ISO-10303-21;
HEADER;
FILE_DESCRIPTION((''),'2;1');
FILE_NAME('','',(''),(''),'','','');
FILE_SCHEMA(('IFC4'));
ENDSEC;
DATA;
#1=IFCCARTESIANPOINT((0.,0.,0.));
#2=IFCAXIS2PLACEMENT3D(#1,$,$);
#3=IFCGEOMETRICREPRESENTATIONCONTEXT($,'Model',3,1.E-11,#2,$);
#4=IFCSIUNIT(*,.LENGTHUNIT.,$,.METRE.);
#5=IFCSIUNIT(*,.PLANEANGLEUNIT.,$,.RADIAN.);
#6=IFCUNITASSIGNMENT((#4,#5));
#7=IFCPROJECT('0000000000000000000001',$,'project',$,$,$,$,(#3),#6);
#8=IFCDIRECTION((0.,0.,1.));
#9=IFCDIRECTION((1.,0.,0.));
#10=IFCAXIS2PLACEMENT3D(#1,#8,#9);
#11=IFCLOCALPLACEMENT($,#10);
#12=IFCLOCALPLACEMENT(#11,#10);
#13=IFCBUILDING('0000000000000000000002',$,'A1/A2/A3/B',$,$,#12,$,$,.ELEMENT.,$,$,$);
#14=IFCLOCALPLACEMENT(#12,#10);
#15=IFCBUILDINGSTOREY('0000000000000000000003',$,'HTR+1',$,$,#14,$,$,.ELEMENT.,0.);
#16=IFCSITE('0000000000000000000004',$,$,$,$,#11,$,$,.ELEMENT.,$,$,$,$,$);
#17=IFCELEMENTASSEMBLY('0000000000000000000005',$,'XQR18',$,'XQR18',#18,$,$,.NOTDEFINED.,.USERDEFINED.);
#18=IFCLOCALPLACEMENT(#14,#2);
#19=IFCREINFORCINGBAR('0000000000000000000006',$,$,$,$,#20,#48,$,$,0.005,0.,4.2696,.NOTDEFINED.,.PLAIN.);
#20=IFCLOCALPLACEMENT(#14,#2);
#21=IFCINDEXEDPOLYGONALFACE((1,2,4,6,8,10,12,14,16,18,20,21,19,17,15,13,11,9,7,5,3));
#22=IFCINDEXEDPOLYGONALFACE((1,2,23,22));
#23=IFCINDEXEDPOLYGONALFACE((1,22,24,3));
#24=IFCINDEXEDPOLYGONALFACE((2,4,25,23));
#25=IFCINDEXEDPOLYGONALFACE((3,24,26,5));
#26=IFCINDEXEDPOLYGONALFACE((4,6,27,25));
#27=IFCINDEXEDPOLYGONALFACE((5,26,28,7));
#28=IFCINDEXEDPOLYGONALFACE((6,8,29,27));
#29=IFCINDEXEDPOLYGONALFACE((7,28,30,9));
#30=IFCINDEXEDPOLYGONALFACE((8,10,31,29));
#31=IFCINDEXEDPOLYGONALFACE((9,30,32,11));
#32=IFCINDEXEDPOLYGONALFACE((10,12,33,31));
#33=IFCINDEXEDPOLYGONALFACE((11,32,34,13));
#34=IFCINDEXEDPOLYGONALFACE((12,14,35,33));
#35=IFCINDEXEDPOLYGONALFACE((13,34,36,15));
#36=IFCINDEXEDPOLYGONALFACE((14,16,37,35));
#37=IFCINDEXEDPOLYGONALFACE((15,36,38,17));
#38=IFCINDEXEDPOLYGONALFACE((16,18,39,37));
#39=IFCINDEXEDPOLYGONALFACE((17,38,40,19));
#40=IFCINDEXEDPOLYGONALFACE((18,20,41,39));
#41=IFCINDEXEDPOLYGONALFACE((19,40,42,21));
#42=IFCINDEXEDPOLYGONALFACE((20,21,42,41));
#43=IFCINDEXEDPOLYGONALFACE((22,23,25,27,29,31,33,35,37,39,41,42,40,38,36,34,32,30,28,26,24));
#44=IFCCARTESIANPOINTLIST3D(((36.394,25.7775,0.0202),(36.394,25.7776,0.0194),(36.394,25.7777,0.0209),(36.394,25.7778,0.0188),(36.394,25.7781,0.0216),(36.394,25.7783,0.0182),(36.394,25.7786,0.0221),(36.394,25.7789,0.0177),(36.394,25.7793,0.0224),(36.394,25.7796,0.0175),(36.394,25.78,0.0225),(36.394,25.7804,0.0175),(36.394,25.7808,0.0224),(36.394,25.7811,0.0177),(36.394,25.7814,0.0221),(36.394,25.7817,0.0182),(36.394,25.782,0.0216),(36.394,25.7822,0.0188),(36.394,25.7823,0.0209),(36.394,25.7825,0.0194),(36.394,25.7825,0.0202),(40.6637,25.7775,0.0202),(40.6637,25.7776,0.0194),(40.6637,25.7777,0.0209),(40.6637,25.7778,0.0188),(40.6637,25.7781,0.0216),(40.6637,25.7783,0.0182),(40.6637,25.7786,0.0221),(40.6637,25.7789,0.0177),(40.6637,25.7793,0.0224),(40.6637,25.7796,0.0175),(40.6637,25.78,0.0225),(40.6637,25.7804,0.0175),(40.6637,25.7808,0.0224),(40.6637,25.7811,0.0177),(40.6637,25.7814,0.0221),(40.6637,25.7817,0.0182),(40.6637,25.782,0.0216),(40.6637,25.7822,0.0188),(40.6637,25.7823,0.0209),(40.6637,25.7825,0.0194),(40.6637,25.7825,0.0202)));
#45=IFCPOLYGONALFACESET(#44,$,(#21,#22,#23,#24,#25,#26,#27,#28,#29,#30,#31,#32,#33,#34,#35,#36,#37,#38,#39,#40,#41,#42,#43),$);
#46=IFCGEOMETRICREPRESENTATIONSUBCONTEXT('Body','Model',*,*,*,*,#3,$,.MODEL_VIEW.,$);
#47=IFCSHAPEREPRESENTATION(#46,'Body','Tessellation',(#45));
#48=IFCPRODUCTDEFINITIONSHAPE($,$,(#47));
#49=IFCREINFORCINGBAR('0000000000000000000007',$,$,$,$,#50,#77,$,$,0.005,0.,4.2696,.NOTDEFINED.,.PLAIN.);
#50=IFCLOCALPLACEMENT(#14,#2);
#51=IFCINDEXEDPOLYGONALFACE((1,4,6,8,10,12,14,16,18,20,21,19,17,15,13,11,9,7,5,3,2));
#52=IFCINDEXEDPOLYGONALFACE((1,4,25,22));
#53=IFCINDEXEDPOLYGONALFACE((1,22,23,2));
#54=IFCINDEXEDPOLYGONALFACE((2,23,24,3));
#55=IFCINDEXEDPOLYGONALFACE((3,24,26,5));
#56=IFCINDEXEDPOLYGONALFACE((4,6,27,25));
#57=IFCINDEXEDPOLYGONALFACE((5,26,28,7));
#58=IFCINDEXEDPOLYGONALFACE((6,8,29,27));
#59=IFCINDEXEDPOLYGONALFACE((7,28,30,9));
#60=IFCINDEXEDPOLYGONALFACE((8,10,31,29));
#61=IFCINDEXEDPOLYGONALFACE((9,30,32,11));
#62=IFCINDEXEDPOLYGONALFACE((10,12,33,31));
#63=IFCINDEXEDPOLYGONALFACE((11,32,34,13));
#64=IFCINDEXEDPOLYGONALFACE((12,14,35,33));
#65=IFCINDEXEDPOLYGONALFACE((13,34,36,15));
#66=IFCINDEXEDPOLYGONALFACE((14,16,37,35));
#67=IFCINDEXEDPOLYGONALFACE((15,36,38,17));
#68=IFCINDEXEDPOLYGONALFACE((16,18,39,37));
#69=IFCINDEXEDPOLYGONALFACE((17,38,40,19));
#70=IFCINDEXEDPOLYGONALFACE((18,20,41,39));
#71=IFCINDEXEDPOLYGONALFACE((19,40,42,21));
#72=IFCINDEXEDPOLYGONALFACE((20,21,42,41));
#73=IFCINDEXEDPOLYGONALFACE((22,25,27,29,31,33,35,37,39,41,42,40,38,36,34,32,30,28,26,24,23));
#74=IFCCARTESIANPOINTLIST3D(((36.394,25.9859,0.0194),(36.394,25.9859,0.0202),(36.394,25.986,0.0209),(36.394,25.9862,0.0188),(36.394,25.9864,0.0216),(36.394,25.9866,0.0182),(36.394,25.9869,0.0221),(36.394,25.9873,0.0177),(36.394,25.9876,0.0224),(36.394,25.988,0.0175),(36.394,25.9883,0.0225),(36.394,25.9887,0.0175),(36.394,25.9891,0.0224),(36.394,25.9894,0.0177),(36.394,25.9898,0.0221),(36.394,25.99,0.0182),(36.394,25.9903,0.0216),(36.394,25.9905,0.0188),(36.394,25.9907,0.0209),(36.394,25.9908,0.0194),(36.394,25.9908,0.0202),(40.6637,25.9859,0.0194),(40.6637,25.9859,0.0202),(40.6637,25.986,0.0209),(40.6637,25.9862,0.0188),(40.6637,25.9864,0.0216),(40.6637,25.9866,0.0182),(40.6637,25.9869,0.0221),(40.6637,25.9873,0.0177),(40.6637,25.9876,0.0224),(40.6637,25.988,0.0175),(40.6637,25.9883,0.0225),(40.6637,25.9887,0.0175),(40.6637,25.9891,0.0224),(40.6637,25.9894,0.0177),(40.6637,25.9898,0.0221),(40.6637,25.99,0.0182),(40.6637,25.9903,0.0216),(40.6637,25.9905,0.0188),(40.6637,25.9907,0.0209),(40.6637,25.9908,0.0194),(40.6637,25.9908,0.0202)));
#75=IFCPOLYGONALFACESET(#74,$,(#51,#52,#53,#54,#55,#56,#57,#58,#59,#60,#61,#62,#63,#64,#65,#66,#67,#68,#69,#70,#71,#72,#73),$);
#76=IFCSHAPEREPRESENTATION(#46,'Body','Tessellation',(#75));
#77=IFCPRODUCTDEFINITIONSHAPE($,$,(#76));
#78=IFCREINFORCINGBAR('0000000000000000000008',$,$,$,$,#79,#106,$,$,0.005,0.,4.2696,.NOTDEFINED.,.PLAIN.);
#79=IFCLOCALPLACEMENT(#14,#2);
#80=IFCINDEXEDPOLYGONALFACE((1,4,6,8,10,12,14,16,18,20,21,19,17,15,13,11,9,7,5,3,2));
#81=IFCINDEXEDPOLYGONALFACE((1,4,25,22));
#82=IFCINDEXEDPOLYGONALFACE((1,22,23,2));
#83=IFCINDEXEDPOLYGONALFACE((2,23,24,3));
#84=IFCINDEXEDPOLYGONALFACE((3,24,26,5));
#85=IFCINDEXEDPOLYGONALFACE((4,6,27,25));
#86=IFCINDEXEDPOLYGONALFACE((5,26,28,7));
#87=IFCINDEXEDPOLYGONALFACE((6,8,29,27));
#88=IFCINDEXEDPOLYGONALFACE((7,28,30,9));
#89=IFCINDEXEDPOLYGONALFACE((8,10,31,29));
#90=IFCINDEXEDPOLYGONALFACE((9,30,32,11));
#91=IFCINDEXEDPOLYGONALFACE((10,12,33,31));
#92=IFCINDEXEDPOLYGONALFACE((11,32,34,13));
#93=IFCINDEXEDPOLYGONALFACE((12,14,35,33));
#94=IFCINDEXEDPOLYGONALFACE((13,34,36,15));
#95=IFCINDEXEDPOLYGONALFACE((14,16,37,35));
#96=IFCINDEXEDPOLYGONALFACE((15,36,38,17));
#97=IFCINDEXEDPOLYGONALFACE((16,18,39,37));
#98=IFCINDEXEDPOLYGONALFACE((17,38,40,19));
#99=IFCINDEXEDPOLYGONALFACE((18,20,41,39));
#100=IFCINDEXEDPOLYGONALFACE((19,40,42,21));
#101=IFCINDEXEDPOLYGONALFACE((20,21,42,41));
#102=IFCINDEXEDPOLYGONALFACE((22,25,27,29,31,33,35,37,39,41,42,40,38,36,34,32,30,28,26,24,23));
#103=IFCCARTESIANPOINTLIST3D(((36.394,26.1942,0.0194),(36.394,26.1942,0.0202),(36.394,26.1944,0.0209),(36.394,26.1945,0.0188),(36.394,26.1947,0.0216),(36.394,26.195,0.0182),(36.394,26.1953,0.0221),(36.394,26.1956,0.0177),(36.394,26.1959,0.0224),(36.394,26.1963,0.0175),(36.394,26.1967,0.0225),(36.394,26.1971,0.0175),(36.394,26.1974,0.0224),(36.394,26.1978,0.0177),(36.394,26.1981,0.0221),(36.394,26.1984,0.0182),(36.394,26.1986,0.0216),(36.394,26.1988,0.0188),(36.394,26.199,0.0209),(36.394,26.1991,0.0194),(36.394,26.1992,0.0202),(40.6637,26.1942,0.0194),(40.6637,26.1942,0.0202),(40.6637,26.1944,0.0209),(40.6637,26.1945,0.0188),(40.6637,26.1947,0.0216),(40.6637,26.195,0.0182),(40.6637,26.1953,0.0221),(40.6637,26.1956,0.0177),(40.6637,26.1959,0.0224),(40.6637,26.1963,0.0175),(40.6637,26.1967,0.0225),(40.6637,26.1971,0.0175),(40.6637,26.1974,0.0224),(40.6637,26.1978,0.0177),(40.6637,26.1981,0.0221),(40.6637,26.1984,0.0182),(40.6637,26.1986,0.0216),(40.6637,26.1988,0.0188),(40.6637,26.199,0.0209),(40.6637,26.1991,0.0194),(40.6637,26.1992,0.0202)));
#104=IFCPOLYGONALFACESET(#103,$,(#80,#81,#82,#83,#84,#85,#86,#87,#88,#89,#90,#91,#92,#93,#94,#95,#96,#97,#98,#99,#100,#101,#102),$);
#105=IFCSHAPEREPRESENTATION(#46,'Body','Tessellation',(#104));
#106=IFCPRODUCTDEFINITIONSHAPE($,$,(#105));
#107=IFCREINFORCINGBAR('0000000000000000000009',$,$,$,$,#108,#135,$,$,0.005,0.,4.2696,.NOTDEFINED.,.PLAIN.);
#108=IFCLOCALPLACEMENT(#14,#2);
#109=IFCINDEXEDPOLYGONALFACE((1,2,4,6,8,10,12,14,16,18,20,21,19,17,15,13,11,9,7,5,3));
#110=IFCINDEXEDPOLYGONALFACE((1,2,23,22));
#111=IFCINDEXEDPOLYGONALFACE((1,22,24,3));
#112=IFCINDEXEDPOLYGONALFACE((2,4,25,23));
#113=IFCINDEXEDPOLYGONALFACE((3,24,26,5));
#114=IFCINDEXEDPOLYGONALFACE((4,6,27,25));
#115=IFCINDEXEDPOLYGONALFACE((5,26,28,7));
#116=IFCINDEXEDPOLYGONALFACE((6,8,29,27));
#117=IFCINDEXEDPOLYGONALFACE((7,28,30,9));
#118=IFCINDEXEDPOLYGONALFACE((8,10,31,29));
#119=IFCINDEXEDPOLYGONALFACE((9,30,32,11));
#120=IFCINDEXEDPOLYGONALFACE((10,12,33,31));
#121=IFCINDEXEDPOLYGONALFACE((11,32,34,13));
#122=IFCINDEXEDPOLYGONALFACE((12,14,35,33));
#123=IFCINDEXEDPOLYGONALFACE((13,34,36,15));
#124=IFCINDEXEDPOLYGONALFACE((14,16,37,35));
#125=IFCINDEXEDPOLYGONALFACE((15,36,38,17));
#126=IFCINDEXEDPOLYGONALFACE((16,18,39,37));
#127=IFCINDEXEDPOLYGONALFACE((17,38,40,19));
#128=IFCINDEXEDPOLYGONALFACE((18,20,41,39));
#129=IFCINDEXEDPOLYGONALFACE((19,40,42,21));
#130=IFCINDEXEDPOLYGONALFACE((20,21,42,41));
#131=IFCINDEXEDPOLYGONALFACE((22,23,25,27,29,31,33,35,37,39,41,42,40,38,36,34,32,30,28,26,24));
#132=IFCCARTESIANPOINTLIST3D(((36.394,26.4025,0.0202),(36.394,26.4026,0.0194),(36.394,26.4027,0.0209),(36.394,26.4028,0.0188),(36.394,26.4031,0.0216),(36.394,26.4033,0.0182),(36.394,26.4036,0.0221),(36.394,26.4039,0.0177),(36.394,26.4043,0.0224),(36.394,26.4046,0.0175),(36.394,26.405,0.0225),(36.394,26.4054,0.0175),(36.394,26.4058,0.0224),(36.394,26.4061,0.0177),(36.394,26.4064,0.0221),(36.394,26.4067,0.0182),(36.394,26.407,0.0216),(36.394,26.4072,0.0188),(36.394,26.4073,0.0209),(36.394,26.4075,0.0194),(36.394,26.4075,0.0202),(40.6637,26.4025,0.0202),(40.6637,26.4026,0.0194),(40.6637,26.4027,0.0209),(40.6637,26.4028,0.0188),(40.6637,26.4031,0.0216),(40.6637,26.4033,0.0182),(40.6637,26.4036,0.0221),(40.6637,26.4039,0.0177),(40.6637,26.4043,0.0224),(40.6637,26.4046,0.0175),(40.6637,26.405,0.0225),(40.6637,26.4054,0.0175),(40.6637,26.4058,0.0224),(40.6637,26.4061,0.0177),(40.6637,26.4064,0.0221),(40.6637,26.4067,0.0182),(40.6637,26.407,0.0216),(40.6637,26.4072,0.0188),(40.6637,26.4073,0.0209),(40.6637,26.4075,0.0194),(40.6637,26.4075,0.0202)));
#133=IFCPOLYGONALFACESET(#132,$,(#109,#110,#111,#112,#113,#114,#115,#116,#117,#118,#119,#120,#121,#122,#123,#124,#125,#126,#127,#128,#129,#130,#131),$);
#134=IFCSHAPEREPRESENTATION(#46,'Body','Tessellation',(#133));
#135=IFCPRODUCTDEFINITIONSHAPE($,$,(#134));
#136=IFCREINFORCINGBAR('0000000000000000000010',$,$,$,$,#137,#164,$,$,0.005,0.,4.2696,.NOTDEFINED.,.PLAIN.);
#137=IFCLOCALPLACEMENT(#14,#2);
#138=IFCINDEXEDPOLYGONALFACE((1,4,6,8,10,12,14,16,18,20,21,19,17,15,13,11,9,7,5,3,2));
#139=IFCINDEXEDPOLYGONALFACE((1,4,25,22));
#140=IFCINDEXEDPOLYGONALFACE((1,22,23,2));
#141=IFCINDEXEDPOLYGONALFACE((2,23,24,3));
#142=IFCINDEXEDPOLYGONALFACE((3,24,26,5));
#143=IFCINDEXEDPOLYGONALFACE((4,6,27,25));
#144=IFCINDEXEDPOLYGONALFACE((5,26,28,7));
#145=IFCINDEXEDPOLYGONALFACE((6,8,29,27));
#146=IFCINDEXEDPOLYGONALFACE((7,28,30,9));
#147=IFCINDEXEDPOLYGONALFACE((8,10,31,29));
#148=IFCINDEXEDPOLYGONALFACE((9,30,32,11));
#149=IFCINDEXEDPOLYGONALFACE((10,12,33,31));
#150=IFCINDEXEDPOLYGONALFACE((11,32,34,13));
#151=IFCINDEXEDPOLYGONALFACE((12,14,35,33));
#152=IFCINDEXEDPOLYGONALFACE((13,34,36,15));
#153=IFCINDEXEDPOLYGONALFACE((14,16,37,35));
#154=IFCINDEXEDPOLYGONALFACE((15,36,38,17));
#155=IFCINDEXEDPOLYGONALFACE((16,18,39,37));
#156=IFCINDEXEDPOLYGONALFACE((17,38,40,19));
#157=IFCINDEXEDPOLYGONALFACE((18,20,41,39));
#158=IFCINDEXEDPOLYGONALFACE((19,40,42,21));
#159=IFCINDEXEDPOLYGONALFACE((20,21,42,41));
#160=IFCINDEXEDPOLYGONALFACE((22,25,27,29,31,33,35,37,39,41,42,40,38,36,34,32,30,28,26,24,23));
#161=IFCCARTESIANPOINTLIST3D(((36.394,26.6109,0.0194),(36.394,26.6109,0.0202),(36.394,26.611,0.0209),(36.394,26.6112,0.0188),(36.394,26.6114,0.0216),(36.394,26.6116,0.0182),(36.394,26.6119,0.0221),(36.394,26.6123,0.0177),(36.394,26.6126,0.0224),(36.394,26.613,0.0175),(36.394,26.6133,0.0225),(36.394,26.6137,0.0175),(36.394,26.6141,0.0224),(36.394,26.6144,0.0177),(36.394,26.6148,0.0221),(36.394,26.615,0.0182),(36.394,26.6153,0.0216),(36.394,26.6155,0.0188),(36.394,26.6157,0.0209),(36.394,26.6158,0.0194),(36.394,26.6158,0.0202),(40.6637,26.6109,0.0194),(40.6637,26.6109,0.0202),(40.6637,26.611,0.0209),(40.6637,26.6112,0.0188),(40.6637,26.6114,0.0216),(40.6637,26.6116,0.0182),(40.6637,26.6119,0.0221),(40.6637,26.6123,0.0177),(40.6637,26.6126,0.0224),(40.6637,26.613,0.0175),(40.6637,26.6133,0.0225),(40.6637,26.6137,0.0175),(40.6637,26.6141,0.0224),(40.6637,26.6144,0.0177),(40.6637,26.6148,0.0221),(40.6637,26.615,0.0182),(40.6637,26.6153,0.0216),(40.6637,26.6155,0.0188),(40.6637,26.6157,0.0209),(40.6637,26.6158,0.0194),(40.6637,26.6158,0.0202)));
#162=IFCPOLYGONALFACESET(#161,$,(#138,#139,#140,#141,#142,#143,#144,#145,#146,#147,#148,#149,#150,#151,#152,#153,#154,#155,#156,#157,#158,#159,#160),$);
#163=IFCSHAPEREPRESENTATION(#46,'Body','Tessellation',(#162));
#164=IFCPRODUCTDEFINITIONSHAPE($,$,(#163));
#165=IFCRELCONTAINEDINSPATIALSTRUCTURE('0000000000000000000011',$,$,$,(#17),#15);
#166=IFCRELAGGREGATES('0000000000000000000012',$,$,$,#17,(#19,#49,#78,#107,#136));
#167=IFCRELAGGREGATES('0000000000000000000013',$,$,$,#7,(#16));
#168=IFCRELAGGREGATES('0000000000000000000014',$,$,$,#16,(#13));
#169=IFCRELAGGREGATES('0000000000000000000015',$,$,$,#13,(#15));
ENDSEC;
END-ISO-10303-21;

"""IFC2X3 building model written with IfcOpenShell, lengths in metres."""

from ifc_helpers import new_model, entity, si_unit, origin, origin_with_axes, place, context, subcontext, project, spatial, shape, element, aggregate, save


model = new_model("IFC2X3")

# Units and contexts
model_context = context("Model", 3, precision=1e-11, world=origin())
body_context = subcontext(model_context, "Body", "Model", "MODEL_VIEW")
ifc_project = project(units=[si_unit("LENGTHUNIT", "METRE"), si_unit("PLANEANGLEUNIT", "RADIAN")], contexts=[model_context])

# Site, building, storey
site_placement = place(None, origin_with_axes())
site = spatial("IfcSite", under=ifc_project, at=site_placement, CompositionType="ELEMENT")
building_placement = place(site_placement, origin_with_axes())
building = spatial("IfcBuilding", under=site, at=building_placement, Name="A1/A2/A3/B", CompositionType="ELEMENT")
storey_placement = place(building_placement, origin_with_axes())
storey = spatial("IfcBuildingStorey", under=building, at=storey_placement, Name="HTR+1", CompositionType="ELEMENT", Elevation=0.0)

# Element assembly, reinforcing bars
assembly_1_placement = place(storey_placement, origin_with_axes())
assembly_1 = element("IfcElementAssembly", 1, at=assembly_1_placement, inside=storey, Name="XQR18", ObjectType="XQR18", AssemblyPlace="NOTDEFINED", PredefinedType="USERDEFINED")
reinforcing_bar_1_placement = place(assembly_1_placement, origin_with_axes())
reinforcing_bar_1 = element("IfcReinforcingBar", 2, at=reinforcing_bar_1_placement, BarLength=4.2696, BarRole="NOTDEFINED", BarSurface="PLAIN", CrossSectionArea=0.0, NominalDiameter=0.005, shapes=[
    shape(body_context, "Body", "AdvancedSweptSolid", [entity("IfcSweptDiskSolid", entity("IfcPolyline", [entity("IfcCartesianPoint", [36.394, 25.78, 0.02]), entity("IfcCartesianPoint", [40.6637, 25.78, 0.02])]), 0.0025, None, 0.0, 4.2696)]),
    shape(body_context, "Body", "AdvancedSweptSolid", [entity("IfcSweptDiskSolid", entity("IfcPolyline", [entity("IfcCartesianPoint", [36.394, 25.78, 0.02]), entity("IfcCartesianPoint", [40.6637, 25.78, 0.02])]), 0.0025, None, 0.0, 4.2696)]),
])
reinforcing_bar_2_placement = place(assembly_1_placement, origin_with_axes())
reinforcing_bar_2 = element("IfcReinforcingBar", 3, at=reinforcing_bar_2_placement, BarLength=4.2696, BarRole="NOTDEFINED", BarSurface="PLAIN", CrossSectionArea=0.0, NominalDiameter=0.005, shapes=[
    shape(body_context, "Body", "AdvancedSweptSolid", [entity("IfcSweptDiskSolid", entity("IfcPolyline", [entity("IfcCartesianPoint", [36.394, 25.9883, 0.02]), entity("IfcCartesianPoint", [40.6637, 25.9883, 0.02])]), 0.0025, None, 0.0, 4.2696)]),
    shape(body_context, "Body", "AdvancedSweptSolid", [entity("IfcSweptDiskSolid", entity("IfcPolyline", [entity("IfcCartesianPoint", [36.394, 25.9883, 0.02]), entity("IfcCartesianPoint", [40.6637, 25.9883, 0.02])]), 0.0025, None, 0.0, 4.2696)]),
])
reinforcing_bar_3_placement = place(assembly_1_placement, origin_with_axes())
reinforcing_bar_3 = element("IfcReinforcingBar", 4, at=reinforcing_bar_3_placement, BarLength=4.2696, BarRole="NOTDEFINED", BarSurface="PLAIN", CrossSectionArea=0.0, NominalDiameter=0.005, shapes=[
    shape(body_context, "Body", "AdvancedSweptSolid", [entity("IfcSweptDiskSolid", entity("IfcPolyline", [entity("IfcCartesianPoint", [36.394, 26.1967, 0.02]), entity("IfcCartesianPoint", [40.6637, 26.1967, 0.02])]), 0.0025, None, 0.0, 4.2696)]),
    shape(body_context, "Body", "AdvancedSweptSolid", [entity("IfcSweptDiskSolid", entity("IfcPolyline", [entity("IfcCartesianPoint", [36.394, 26.1967, 0.02]), entity("IfcCartesianPoint", [40.6637, 26.1967, 0.02])]), 0.0025, None, 0.0, 4.2696)]),
])
reinforcing_bar_4_placement = place(assembly_1_placement, origin_with_axes())
reinforcing_bar_4 = element("IfcReinforcingBar", 5, at=reinforcing_bar_4_placement, BarLength=4.2696, BarRole="NOTDEFINED", BarSurface="PLAIN", CrossSectionArea=0.0, NominalDiameter=0.005, shapes=[
    shape(body_context, "Body", "AdvancedSweptSolid", [entity("IfcSweptDiskSolid", entity("IfcPolyline", [entity("IfcCartesianPoint", [36.394, 26.405, 0.02]), entity("IfcCartesianPoint", [40.6637, 26.405, 0.02])]), 0.0025, None, 0.0, 4.2696)]),
    shape(body_context, "Body", "AdvancedSweptSolid", [entity("IfcSweptDiskSolid", entity("IfcPolyline", [entity("IfcCartesianPoint", [36.394, 26.405, 0.02]), entity("IfcCartesianPoint", [40.6637, 26.405, 0.02])]), 0.0025, None, 0.0, 4.2696)]),
])
reinforcing_bar_5_placement = place(assembly_1_placement, origin_with_axes())
reinforcing_bar_5 = element("IfcReinforcingBar", 6, at=reinforcing_bar_5_placement, BarLength=4.2696, BarRole="NOTDEFINED", BarSurface="PLAIN", CrossSectionArea=0.0, NominalDiameter=0.005, shapes=[
    shape(body_context, "Body", "AdvancedSweptSolid", [entity("IfcSweptDiskSolid", entity("IfcPolyline", [entity("IfcCartesianPoint", [36.394, 26.6133, 0.02]), entity("IfcCartesianPoint", [40.6637, 26.6133, 0.02])]), 0.0025, None, 0.0, 4.2696)]),
    shape(body_context, "Body", "AdvancedSweptSolid", [entity("IfcSweptDiskSolid", entity("IfcPolyline", [entity("IfcCartesianPoint", [36.394, 26.6133, 0.02]), entity("IfcCartesianPoint", [40.6637, 26.6133, 0.02])]), 0.0025, None, 0.0, 4.2696)]),
])
aggregate(assembly_1, [reinforcing_bar_1, reinforcing_bar_2, reinforcing_bar_3, reinforcing_bar_4, reinforcing_bar_5])

save(model, "model.ifc")
